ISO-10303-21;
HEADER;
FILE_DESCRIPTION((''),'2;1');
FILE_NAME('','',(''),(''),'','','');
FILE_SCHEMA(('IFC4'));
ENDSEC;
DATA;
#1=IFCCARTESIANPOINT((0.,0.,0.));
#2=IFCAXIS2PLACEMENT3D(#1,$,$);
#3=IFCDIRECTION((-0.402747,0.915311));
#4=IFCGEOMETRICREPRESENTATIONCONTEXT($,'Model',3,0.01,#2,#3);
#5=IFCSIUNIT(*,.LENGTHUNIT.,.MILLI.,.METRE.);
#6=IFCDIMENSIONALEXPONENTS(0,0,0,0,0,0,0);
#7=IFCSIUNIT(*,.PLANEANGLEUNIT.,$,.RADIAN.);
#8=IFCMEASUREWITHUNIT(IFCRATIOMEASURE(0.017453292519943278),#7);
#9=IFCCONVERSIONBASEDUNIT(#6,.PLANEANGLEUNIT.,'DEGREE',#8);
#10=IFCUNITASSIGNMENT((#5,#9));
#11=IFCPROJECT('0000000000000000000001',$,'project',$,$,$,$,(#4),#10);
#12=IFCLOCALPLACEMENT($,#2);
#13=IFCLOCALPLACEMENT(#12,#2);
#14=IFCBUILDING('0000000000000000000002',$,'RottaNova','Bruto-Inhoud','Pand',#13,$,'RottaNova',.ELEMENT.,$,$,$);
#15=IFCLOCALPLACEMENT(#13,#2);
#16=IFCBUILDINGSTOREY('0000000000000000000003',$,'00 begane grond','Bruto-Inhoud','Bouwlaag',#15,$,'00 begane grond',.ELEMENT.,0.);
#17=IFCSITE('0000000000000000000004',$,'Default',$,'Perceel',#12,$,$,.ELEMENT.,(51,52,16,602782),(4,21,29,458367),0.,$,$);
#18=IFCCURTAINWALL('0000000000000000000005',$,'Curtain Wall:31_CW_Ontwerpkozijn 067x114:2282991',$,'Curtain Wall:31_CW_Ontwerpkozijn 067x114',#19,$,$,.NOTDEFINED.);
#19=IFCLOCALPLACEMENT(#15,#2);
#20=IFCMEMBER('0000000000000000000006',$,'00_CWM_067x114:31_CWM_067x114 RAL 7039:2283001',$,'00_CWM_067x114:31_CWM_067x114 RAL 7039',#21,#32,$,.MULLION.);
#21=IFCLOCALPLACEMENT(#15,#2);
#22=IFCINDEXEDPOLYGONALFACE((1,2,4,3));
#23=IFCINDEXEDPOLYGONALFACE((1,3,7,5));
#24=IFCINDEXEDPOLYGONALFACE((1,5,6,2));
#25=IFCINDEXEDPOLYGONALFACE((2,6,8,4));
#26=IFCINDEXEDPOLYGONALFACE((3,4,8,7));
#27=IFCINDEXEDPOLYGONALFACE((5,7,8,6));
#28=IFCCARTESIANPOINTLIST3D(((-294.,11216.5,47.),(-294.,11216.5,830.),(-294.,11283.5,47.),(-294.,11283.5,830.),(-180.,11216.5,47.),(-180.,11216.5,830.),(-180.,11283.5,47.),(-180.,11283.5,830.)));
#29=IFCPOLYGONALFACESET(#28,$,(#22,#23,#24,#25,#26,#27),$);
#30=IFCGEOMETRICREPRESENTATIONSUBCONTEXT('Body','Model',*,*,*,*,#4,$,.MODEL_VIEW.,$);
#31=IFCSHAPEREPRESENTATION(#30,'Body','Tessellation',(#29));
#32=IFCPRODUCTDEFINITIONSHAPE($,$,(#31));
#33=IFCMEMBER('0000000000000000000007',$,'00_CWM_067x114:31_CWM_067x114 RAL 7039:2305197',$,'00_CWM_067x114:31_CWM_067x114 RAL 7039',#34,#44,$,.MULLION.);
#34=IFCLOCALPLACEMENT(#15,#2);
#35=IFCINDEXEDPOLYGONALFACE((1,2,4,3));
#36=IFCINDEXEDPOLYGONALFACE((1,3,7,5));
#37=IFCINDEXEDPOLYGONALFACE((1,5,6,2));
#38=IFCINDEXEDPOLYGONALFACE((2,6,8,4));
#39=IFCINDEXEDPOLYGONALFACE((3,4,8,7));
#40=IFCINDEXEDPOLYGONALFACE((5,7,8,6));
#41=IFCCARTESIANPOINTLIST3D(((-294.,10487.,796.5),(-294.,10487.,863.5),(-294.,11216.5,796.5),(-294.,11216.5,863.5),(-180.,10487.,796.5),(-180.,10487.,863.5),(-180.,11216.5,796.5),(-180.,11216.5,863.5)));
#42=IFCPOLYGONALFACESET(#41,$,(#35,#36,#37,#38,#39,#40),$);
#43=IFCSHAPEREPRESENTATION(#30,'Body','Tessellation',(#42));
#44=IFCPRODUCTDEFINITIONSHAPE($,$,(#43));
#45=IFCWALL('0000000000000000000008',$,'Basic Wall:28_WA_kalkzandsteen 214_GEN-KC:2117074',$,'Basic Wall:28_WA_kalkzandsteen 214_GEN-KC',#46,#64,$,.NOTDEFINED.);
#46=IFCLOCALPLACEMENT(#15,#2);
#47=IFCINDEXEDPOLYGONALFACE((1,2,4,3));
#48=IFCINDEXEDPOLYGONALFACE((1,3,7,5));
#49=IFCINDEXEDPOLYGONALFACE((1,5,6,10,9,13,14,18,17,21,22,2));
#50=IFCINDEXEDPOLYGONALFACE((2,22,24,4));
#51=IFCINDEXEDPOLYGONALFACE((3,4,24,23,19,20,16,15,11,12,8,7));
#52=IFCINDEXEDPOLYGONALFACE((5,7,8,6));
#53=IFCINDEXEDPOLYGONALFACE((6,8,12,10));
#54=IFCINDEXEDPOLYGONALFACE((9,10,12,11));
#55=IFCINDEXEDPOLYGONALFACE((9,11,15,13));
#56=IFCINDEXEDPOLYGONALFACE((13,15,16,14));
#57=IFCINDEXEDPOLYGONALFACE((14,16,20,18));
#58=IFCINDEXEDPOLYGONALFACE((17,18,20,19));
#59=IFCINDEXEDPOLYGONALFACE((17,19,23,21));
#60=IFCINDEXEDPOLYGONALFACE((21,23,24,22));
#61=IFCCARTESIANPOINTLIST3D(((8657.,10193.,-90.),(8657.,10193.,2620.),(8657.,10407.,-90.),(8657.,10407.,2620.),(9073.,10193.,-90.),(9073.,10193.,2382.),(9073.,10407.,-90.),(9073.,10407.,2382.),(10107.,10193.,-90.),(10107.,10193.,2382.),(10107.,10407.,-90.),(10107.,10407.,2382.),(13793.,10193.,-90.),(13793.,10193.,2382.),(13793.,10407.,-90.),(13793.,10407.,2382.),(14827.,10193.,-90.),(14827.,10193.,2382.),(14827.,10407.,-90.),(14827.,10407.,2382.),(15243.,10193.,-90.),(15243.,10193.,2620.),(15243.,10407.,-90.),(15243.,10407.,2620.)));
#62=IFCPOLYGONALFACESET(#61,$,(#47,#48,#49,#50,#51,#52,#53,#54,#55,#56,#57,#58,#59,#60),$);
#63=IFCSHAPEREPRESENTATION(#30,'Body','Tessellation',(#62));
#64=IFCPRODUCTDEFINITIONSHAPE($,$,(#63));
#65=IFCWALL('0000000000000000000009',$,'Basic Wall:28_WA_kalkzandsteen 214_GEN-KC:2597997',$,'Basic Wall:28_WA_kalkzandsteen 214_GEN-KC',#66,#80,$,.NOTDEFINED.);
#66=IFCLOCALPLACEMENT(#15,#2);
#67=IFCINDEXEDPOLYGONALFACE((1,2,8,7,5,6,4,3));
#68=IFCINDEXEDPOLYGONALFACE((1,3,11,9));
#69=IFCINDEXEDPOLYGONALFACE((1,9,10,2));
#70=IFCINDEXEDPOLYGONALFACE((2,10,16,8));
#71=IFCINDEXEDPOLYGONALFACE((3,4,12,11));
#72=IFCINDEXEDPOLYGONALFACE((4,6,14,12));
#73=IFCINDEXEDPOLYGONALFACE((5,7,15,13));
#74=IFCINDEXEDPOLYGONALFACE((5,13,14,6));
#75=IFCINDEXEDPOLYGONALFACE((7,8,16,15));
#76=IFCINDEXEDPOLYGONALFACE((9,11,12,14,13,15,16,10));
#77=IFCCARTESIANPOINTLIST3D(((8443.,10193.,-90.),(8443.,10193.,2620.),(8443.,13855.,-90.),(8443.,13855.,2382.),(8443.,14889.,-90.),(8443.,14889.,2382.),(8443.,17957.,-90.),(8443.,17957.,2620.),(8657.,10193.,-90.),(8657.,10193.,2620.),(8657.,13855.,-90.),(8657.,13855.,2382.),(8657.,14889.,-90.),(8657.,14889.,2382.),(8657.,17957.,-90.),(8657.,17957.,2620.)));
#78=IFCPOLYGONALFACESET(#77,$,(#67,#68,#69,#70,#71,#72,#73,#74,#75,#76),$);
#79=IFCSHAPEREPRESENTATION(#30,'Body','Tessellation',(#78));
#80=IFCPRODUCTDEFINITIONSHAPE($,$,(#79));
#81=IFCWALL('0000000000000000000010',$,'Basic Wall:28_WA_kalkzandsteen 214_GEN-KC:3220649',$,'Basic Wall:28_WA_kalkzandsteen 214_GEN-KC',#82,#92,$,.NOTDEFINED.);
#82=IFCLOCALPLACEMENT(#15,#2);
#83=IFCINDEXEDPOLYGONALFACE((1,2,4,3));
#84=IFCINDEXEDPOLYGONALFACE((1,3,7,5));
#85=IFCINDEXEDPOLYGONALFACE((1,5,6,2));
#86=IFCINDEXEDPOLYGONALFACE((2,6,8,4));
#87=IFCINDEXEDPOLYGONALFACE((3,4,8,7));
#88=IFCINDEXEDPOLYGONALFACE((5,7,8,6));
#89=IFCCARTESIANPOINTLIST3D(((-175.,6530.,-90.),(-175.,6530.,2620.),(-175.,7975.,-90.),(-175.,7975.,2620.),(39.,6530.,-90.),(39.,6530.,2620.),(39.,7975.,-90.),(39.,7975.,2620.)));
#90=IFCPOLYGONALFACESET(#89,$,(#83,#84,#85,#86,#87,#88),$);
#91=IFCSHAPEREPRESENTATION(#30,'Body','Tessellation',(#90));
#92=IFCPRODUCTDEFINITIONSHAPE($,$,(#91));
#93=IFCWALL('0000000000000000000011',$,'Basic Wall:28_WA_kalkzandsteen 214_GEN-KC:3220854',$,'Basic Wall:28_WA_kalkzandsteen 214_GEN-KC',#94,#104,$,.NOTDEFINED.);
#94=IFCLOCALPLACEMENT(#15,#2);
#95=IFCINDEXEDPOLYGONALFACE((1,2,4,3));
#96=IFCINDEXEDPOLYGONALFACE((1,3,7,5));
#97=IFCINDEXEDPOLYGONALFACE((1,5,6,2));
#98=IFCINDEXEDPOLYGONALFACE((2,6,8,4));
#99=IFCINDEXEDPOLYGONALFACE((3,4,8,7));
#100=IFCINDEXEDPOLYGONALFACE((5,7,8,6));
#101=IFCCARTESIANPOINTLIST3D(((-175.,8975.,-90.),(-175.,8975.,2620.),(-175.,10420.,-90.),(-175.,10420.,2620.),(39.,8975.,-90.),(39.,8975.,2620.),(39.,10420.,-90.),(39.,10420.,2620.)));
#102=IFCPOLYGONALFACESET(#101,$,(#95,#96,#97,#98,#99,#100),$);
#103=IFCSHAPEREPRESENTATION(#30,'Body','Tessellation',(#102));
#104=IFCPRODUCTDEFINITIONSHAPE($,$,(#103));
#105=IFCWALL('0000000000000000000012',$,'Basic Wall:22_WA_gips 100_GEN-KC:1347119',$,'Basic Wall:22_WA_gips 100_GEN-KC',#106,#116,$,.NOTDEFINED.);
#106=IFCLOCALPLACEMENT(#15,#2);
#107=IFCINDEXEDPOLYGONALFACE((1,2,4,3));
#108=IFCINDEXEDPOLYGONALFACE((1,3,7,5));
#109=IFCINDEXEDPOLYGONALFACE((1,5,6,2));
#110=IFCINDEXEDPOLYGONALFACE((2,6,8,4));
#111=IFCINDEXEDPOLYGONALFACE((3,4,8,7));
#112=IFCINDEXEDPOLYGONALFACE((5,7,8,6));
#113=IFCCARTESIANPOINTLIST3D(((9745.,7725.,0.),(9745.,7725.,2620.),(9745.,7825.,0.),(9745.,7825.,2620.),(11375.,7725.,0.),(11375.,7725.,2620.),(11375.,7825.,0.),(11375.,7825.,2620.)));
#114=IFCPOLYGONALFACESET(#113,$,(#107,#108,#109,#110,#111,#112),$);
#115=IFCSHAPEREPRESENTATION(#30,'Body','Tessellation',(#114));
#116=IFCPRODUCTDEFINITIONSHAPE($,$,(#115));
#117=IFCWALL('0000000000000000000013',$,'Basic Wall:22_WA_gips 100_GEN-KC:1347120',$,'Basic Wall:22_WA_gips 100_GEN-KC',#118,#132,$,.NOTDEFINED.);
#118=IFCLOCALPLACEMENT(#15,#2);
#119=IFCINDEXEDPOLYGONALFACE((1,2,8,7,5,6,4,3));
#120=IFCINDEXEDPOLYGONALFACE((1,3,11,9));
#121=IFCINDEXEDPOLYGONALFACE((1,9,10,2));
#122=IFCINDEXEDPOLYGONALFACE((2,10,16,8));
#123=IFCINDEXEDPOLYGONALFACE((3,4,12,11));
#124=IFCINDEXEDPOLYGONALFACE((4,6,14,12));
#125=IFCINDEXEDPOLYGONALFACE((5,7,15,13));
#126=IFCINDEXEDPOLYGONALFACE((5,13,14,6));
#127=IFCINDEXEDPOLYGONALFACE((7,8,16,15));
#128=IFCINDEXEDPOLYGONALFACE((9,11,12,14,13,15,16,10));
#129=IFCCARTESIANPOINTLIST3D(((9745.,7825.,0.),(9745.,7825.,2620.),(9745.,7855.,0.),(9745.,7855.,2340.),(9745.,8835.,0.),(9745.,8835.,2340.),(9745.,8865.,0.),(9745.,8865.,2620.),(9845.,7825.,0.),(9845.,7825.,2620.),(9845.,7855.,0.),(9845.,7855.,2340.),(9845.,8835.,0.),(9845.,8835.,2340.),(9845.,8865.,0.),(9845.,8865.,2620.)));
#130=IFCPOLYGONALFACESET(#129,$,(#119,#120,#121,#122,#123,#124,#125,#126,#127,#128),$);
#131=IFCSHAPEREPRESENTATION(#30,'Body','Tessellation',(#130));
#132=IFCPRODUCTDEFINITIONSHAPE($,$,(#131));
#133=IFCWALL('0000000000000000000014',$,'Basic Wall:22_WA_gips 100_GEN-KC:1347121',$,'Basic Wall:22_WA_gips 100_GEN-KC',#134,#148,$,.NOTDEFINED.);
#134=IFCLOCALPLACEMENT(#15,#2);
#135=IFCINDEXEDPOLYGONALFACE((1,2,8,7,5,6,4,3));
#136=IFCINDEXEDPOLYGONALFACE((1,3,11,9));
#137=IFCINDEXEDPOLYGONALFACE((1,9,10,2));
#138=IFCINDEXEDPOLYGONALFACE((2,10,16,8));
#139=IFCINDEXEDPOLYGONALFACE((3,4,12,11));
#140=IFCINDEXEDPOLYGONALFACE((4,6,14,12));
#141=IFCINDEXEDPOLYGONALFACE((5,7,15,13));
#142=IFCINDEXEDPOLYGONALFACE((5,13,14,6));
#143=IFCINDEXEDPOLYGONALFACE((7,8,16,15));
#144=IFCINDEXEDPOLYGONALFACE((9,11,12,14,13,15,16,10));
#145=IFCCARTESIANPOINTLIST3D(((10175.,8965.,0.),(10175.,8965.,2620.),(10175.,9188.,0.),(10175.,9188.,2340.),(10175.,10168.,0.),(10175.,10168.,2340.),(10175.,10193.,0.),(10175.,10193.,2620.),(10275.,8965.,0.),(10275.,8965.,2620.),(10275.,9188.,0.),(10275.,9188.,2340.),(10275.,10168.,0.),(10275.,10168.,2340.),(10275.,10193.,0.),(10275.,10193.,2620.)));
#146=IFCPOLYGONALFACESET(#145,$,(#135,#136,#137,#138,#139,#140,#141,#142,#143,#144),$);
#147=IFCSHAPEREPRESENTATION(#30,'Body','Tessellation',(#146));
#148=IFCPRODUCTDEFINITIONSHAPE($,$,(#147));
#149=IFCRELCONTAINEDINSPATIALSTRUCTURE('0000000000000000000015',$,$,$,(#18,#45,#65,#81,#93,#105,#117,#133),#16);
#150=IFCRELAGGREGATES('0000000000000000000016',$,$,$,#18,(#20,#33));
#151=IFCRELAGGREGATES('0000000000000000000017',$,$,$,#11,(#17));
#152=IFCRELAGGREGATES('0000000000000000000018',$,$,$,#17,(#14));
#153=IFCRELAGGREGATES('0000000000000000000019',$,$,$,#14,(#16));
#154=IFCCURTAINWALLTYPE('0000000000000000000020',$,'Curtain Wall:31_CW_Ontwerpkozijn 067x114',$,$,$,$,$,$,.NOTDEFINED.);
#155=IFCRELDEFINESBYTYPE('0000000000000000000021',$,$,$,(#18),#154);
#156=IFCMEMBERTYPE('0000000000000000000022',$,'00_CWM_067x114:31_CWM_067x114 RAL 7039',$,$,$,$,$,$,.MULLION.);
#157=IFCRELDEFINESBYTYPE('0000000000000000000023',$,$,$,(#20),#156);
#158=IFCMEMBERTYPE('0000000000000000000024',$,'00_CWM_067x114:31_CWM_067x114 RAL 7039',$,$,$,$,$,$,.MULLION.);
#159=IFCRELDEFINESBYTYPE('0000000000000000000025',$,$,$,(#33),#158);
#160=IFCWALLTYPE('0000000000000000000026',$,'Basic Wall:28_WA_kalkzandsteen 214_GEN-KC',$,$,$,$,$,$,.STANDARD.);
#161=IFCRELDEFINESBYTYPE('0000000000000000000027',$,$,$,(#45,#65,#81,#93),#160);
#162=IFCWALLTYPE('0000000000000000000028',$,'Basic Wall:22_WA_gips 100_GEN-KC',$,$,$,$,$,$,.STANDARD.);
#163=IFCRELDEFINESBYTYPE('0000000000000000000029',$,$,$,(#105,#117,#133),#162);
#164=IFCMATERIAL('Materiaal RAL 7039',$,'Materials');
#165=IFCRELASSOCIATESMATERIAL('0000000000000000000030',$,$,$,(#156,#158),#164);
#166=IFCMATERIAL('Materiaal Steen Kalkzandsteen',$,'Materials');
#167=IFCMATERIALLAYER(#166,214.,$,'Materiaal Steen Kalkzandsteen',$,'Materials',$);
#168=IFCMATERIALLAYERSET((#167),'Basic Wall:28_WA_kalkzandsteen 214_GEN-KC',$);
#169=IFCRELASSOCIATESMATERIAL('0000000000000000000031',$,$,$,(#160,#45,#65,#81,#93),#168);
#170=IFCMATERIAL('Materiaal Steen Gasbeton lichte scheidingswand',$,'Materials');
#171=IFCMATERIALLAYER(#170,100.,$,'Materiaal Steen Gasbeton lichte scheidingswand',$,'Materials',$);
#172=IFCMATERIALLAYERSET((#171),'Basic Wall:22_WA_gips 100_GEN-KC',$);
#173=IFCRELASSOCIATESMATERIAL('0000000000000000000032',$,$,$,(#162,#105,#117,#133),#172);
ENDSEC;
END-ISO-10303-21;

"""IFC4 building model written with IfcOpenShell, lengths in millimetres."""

from ifc_helpers import new_model, entity, si_unit, converted_unit, direction, frame, frame_2d, origin, origin_2d_with_axis, place, context, subcontext, project, spatial, rectangle, extrude, source, transform, mapped, material, layer, layer_set, material_profile, profile_set, type_object, type_shapes, element, aggregate, save


model = new_model("IFC4")

# Units and contexts
model_context = context("Model", 3, precision=0.01, world=origin(), true_north=direction((-0.402747, 0.915311)))
body_context = subcontext(model_context, "Body", "Model", "MODEL_VIEW")
ifc_project = project(units=[si_unit("LENGTHUNIT", "METRE", prefix="MILLI"), converted_unit("PLANEANGLEUNIT", "DEGREE", entity("IfcRatioMeasure", 0.017453292519943278), si_unit("PLANEANGLEUNIT", "RADIAN"), dimensions=[0, 0, 0, 0, 0, 0, 0])], contexts=[model_context])

# Site, building, storey
site_placement = place(None, origin())
site = spatial("IfcSite", under=ifc_project, at=site_placement, Name="Default", ObjectType="Perceel", CompositionType="ELEMENT", RefLatitude=(51, 52, 16, 602782), RefLongitude=(4, 21, 29, 458367), RefElevation=0.0)
building_placement = place(site_placement, origin())
building = spatial("IfcBuilding", under=site, at=building_placement, Name="RottaNova", Description="Bruto-Inhoud", ObjectType="Pand", LongName="RottaNova", CompositionType="ELEMENT")
storey_placement = place(building_placement, origin())
storey = spatial("IfcBuildingStorey", under=building, at=storey_placement, Name="00 begane grond", Description="Bruto-Inhoud", ObjectType="Bouwlaag", LongName="00 begane grond", CompositionType="ELEMENT", Elevation=0.0)

# Curtain wall
curtain_wall_type = type_object("IfcCurtainWallType", Name="Curtain Wall:31_CW_Ontwerpkozijn 067x114", PredefinedType="NOTDEFINED")
curtain_wall_1_placement = place(storey_placement, origin())
curtain_wall_1 = element("IfcCurtainWall", 1, at=curtain_wall_1_placement, inside=storey, type_object=curtain_wall_type, Name="Curtain Wall:31_CW_Ontwerpkozijn 067x114:2282991", ObjectType="Curtain Wall:31_CW_Ontwerpkozijn 067x114", PredefinedType="NOTDEFINED")
ifc_material_1 = material(Name="Materiaal RAL 7039", Category="Materials")
ifc_material_profile = material_profile(ifc_material_1, rectangle(XDim=114.0, YDim=67.0, at=origin_2d_with_axis()), Name="31_CWM_067x114 RAL 7039")
ifc_profile_set = profile_set([ifc_material_profile], Name="31_CWM_067x114 RAL 7039")

# Members
member_type_1 = type_object("IfcMemberType", Name="00_CWM_067x114:31_CWM_067x114 RAL 7039", PredefinedType="MULLION", material=ifc_profile_set)
shared_shape_1 = source(origin(), body_context, "Body", "SweptSolid", [
    extrude(rectangle(XDim=114.0, YDim=67.0, at=frame_2d((0.0, 0.0), x_axis=(1.0, 0.0))), frame((0.0, -57.0, -783.0), z_axis=(0.0, 0.0, 1.0), x_axis=(0.0, -1.0, 0.0)), (0.0, 0.0, 1.0), 783.0),
])
type_shapes(member_type_1, [shared_shape_1])
member_1_placement = place(curtain_wall_1_placement, frame((-180.0, 11250.0, 47.0), z_axis=(0.0, 0.0, -1.0), x_axis=(0.0, 1.0, 0.0)))
member_1 = element("IfcMember", 2, at=member_1_placement, type_object=member_type_1, Name="00_CWM_067x114:31_CWM_067x114 RAL 7039:2283001", ObjectType="00_CWM_067x114:31_CWM_067x114 RAL 7039", PredefinedType="MULLION", context=body_context, shape_type="MappedRepresentation", body=[
    mapped(shared_shape_1, transform((0.0, 0.0, 0.0), scale=1.0)),
])
member_type_2 = type_object("IfcMemberType", Name="00_CWM_067x114:31_CWM_067x114 RAL 7039", PredefinedType="MULLION", material=ifc_profile_set)
shared_shape_2 = source(origin(), body_context, "Body", "SweptSolid", [
    extrude(rectangle(XDim=114.0, YDim=67.0, at=origin_2d_with_axis()), frame((0.0, -57.0, -729.5), z_axis=(0.0, 0.0, 1.0), x_axis=(0.0, -1.0, 0.0)), (0.0, 0.0, 1.0), 729.5),
])
type_shapes(member_type_2, [shared_shape_2])
member_2_placement = place(curtain_wall_1_placement, frame((-180.0, 11216.5, 830.0), z_axis=(0.0, 1.0, 0.0), x_axis=(0.0, 0.0, 1.0)))
member_2 = element("IfcMember", 3, at=member_2_placement, type_object=member_type_2, Name="00_CWM_067x114:31_CWM_067x114 RAL 7039:2305197", ObjectType="00_CWM_067x114:31_CWM_067x114 RAL 7039", PredefinedType="MULLION", context=body_context, shape_type="MappedRepresentation", body=[
    mapped(shared_shape_2, transform((0.0, 0.0, 0.0), scale=1.0)),
])

# Wall, openings
ifc_material_2 = material(Name="Materiaal Steen Kalkzandsteen", Category="Materials")
ifc_layer_1 = layer(ifc_material_2, 214.0, Name="Materiaal Steen Kalkzandsteen", Category="Materials")
ifc_layer_set_1 = layer_set([ifc_layer_1], Name="Basic Wall:28_WA_kalkzandsteen 214_GEN-KC")
wall_type_1 = type_object("IfcWallType", Name="Basic Wall:28_WA_kalkzandsteen 214_GEN-KC", PredefinedType="STANDARD", material=ifc_layer_set_1)
wall_1_placement = place(storey_placement, frame((8657.0, 10300.0, -90.0)))
wall_1 = element("IfcWall", 4, at=wall_1_placement, inside=storey, type_object=wall_type_1, material=ifc_layer_set_1, Name="Basic Wall:28_WA_kalkzandsteen 214_GEN-KC:2117074", ObjectType="Basic Wall:28_WA_kalkzandsteen 214_GEN-KC", PredefinedType="NOTDEFINED", context=body_context, shape_type="SweptSolid", body=[
    extrude(rectangle(XDim=6586.0, YDim=214.0, at=frame_2d((3293.0, 0.0), x_axis=(-1.0, 0.0))), origin(), (0.0, 0.0, 1.0), 2710.0),
])
opening_1_placement = place(wall_1_placement, frame((5136.0, -107.0, 0.0)))
element("IfcOpeningElement", 5, at=opening_1_placement, cuts=wall_1, PredefinedType="OPENING", context=body_context, shape_type="SweptSolid", body=[
    extrude(rectangle(XDim=2472.0, YDim=1034.0, at=frame_2d((0.0, 0.0), x_axis=(1.0, 0.0))), frame((517.0, 0.0, 1236.0), z_axis=(0.0, 1.0, 0.0), x_axis=(0.0, 0.0, -1.0)), (0.0, 0.0, 1.0), 214.0),
])
opening_2_placement = place(wall_1_placement, frame((416.0, -107.0, 0.0)))
element("IfcOpeningElement", 6, at=opening_2_placement, cuts=wall_1, PredefinedType="OPENING", context=body_context, shape_type="SweptSolid", body=[
    extrude(rectangle(XDim=2472.0, YDim=1034.0, at=frame_2d((0.0, 0.0), x_axis=(1.0, 0.0))), frame((517.0, 0.0, 1236.0), z_axis=(0.0, 1.0, 0.0), x_axis=(0.0, 0.0, -1.0)), (0.0, 0.0, 1.0), 214.0),
])

# Wall, opening
wall_2_placement = place(storey_placement, frame((8550.0, 10193.0, -90.0), z_axis=(0.0, 0.0, 1.0), x_axis=(0.0, 1.0, 0.0)))
wall_2 = element("IfcWall", 7, at=wall_2_placement, inside=storey, type_object=wall_type_1, material=ifc_layer_set_1, Name="Basic Wall:28_WA_kalkzandsteen 214_GEN-KC:2597997", ObjectType="Basic Wall:28_WA_kalkzandsteen 214_GEN-KC", PredefinedType="NOTDEFINED", context=body_context, shape_type="SweptSolid", body=[
    extrude(rectangle(XDim=7764.0, YDim=214.0, at=frame_2d((3882.0, 0.0), x_axis=(1.0, 0.0))), origin(), (0.0, 0.0, 1.0), 2710.0),
])
opening_3_placement = place(wall_2_placement, frame((3662.0, 107.0, 0.0)))
element("IfcOpeningElement", 8, at=opening_3_placement, cuts=wall_2, PredefinedType="OPENING", context=body_context, shape_type="SweptSolid", body=[
    extrude(rectangle(XDim=2472.0, YDim=1034.0, at=frame_2d((0.0, 0.0), x_axis=(1.0, 0.0))), frame((517.0, -214.0, 1236.0), z_axis=(0.0, 1.0, 0.0), x_axis=(0.0, 0.0, -1.0)), (0.0, 0.0, 1.0), 214.0),
])

# Walls
wall_3_placement = place(storey_placement, frame((-68.0, 6530.0, -90.0), z_axis=(0.0, 0.0, 1.0), x_axis=(0.0, 1.0, 0.0)))
element("IfcWall", 9, at=wall_3_placement, inside=storey, type_object=wall_type_1, material=ifc_layer_set_1, Name="Basic Wall:28_WA_kalkzandsteen 214_GEN-KC:3220649", ObjectType="Basic Wall:28_WA_kalkzandsteen 214_GEN-KC", PredefinedType="NOTDEFINED", context=body_context, shape_type="SweptSolid", body=[
    extrude(rectangle(XDim=1445.0, YDim=214.0, at=frame_2d((722.5, 0.0), x_axis=(-1.0, 0.0))), origin(), (0.0, 0.0, 1.0), 2710.0),
])
wall_4_placement = place(storey_placement, frame((-68.0, 8975.0, -90.0), z_axis=(0.0, 0.0, 1.0), x_axis=(0.0, 1.0, 0.0)))
element("IfcWall", 10, at=wall_4_placement, inside=storey, type_object=wall_type_1, material=ifc_layer_set_1, Name="Basic Wall:28_WA_kalkzandsteen 214_GEN-KC:3220854", ObjectType="Basic Wall:28_WA_kalkzandsteen 214_GEN-KC", PredefinedType="NOTDEFINED", context=body_context, shape_type="SweptSolid", body=[
    extrude(rectangle(XDim=1445.0, YDim=214.0, at=frame_2d((722.5, 0.0), x_axis=(-1.0, 0.0))), origin(), (0.0, 0.0, 1.0), 2710.0),
])
ifc_material_3 = material(Name="Materiaal Steen Gasbeton lichte scheidingswand", Category="Materials")
ifc_layer_2 = layer(ifc_material_3, 100.0, Name="Materiaal Steen Gasbeton lichte scheidingswand", Category="Materials")
ifc_layer_set_2 = layer_set([ifc_layer_2], Name="Basic Wall:22_WA_gips 100_GEN-KC")
wall_type_2 = type_object("IfcWallType", Name="Basic Wall:22_WA_gips 100_GEN-KC", PredefinedType="STANDARD", material=ifc_layer_set_2)
wall_5_placement = place(storey_placement, frame((9745.0, 7775.0, 0.0)))
element("IfcWall", 11, at=wall_5_placement, inside=storey, type_object=wall_type_2, material=ifc_layer_set_2, Name="Basic Wall:22_WA_gips 100_GEN-KC:1347119", ObjectType="Basic Wall:22_WA_gips 100_GEN-KC", PredefinedType="NOTDEFINED", context=body_context, shape_type="SweptSolid", body=[
    extrude(rectangle(XDim=1630.0, YDim=100.0, at=frame_2d((815.0, 0.0), x_axis=(-1.0, 0.0))), origin(), (0.0, 0.0, 1.0), 2620.0),
])

# Walls, openings
wall_6_placement = place(storey_placement, frame((9795.0, 8865.0, 0.0), z_axis=(0.0, 0.0, 1.0), x_axis=(0.0, -1.0, 0.0)))
wall_6 = element("IfcWall", 12, at=wall_6_placement, inside=storey, type_object=wall_type_2, material=ifc_layer_set_2, Name="Basic Wall:22_WA_gips 100_GEN-KC:1347120", ObjectType="Basic Wall:22_WA_gips 100_GEN-KC", PredefinedType="NOTDEFINED", context=body_context, shape_type="SweptSolid", body=[
    extrude(rectangle(XDim=1040.0, YDim=100.0, at=frame_2d((520.0, 0.0), x_axis=(1.0, 0.0))), origin(), (0.0, 0.0, 1.0), 2620.0),
])
opening_4_placement = place(wall_6_placement, frame((1010.0, 50.0, -90.0)))
element("IfcOpeningElement", 13, at=opening_4_placement, cuts=wall_6, PredefinedType="OPENING", context=body_context, shape_type="SweptSolid", body=[
    extrude(rectangle(XDim=2430.0, YDim=980.0, at=frame_2d((1215.0, 490.0), x_axis=(1.0, 0.0))), frame((0.0, 0.0, 0.0), z_axis=(0.0, -1.0, 0.0), x_axis=(0.0, 0.0, 1.0)), (0.0, 0.0, 1.0), 100.0),
])
wall_7_placement = place(storey_placement, frame((10225.0, 8965.0, 0.0), z_axis=(0.0, 0.0, 1.0), x_axis=(0.0, 1.0, 0.0)))
wall_7 = element("IfcWall", 14, at=wall_7_placement, inside=storey, type_object=wall_type_2, material=ifc_layer_set_2, Name="Basic Wall:22_WA_gips 100_GEN-KC:1347121", ObjectType="Basic Wall:22_WA_gips 100_GEN-KC", PredefinedType="NOTDEFINED", context=body_context, shape_type="SweptSolid", body=[
    extrude(rectangle(XDim=1228.0, YDim=100.0, at=frame_2d((614.0, 0.0), x_axis=(1.0, 0.0))), origin(), (0.0, 0.0, 1.0), 2620.0),
])
opening_5_placement = place(wall_7_placement, frame((223.0, -50.0, -90.0)))
element("IfcOpeningElement", 15, at=opening_5_placement, cuts=wall_7, PredefinedType="OPENING", context=body_context, shape_type="SweptSolid", body=[
    extrude(rectangle(XDim=2430.0, YDim=980.0, at=frame_2d((1215.0, 490.0), x_axis=(1.0, 0.0))), frame((0.0, 0.0, 0.0), z_axis=(0.0, 1.0, 0.0), x_axis=(0.0, 0.0, 1.0)), (0.0, 0.0, 1.0), 100.0),
])

aggregate(curtain_wall_1, [member_1, member_2])

save(model, "model.ifc")
